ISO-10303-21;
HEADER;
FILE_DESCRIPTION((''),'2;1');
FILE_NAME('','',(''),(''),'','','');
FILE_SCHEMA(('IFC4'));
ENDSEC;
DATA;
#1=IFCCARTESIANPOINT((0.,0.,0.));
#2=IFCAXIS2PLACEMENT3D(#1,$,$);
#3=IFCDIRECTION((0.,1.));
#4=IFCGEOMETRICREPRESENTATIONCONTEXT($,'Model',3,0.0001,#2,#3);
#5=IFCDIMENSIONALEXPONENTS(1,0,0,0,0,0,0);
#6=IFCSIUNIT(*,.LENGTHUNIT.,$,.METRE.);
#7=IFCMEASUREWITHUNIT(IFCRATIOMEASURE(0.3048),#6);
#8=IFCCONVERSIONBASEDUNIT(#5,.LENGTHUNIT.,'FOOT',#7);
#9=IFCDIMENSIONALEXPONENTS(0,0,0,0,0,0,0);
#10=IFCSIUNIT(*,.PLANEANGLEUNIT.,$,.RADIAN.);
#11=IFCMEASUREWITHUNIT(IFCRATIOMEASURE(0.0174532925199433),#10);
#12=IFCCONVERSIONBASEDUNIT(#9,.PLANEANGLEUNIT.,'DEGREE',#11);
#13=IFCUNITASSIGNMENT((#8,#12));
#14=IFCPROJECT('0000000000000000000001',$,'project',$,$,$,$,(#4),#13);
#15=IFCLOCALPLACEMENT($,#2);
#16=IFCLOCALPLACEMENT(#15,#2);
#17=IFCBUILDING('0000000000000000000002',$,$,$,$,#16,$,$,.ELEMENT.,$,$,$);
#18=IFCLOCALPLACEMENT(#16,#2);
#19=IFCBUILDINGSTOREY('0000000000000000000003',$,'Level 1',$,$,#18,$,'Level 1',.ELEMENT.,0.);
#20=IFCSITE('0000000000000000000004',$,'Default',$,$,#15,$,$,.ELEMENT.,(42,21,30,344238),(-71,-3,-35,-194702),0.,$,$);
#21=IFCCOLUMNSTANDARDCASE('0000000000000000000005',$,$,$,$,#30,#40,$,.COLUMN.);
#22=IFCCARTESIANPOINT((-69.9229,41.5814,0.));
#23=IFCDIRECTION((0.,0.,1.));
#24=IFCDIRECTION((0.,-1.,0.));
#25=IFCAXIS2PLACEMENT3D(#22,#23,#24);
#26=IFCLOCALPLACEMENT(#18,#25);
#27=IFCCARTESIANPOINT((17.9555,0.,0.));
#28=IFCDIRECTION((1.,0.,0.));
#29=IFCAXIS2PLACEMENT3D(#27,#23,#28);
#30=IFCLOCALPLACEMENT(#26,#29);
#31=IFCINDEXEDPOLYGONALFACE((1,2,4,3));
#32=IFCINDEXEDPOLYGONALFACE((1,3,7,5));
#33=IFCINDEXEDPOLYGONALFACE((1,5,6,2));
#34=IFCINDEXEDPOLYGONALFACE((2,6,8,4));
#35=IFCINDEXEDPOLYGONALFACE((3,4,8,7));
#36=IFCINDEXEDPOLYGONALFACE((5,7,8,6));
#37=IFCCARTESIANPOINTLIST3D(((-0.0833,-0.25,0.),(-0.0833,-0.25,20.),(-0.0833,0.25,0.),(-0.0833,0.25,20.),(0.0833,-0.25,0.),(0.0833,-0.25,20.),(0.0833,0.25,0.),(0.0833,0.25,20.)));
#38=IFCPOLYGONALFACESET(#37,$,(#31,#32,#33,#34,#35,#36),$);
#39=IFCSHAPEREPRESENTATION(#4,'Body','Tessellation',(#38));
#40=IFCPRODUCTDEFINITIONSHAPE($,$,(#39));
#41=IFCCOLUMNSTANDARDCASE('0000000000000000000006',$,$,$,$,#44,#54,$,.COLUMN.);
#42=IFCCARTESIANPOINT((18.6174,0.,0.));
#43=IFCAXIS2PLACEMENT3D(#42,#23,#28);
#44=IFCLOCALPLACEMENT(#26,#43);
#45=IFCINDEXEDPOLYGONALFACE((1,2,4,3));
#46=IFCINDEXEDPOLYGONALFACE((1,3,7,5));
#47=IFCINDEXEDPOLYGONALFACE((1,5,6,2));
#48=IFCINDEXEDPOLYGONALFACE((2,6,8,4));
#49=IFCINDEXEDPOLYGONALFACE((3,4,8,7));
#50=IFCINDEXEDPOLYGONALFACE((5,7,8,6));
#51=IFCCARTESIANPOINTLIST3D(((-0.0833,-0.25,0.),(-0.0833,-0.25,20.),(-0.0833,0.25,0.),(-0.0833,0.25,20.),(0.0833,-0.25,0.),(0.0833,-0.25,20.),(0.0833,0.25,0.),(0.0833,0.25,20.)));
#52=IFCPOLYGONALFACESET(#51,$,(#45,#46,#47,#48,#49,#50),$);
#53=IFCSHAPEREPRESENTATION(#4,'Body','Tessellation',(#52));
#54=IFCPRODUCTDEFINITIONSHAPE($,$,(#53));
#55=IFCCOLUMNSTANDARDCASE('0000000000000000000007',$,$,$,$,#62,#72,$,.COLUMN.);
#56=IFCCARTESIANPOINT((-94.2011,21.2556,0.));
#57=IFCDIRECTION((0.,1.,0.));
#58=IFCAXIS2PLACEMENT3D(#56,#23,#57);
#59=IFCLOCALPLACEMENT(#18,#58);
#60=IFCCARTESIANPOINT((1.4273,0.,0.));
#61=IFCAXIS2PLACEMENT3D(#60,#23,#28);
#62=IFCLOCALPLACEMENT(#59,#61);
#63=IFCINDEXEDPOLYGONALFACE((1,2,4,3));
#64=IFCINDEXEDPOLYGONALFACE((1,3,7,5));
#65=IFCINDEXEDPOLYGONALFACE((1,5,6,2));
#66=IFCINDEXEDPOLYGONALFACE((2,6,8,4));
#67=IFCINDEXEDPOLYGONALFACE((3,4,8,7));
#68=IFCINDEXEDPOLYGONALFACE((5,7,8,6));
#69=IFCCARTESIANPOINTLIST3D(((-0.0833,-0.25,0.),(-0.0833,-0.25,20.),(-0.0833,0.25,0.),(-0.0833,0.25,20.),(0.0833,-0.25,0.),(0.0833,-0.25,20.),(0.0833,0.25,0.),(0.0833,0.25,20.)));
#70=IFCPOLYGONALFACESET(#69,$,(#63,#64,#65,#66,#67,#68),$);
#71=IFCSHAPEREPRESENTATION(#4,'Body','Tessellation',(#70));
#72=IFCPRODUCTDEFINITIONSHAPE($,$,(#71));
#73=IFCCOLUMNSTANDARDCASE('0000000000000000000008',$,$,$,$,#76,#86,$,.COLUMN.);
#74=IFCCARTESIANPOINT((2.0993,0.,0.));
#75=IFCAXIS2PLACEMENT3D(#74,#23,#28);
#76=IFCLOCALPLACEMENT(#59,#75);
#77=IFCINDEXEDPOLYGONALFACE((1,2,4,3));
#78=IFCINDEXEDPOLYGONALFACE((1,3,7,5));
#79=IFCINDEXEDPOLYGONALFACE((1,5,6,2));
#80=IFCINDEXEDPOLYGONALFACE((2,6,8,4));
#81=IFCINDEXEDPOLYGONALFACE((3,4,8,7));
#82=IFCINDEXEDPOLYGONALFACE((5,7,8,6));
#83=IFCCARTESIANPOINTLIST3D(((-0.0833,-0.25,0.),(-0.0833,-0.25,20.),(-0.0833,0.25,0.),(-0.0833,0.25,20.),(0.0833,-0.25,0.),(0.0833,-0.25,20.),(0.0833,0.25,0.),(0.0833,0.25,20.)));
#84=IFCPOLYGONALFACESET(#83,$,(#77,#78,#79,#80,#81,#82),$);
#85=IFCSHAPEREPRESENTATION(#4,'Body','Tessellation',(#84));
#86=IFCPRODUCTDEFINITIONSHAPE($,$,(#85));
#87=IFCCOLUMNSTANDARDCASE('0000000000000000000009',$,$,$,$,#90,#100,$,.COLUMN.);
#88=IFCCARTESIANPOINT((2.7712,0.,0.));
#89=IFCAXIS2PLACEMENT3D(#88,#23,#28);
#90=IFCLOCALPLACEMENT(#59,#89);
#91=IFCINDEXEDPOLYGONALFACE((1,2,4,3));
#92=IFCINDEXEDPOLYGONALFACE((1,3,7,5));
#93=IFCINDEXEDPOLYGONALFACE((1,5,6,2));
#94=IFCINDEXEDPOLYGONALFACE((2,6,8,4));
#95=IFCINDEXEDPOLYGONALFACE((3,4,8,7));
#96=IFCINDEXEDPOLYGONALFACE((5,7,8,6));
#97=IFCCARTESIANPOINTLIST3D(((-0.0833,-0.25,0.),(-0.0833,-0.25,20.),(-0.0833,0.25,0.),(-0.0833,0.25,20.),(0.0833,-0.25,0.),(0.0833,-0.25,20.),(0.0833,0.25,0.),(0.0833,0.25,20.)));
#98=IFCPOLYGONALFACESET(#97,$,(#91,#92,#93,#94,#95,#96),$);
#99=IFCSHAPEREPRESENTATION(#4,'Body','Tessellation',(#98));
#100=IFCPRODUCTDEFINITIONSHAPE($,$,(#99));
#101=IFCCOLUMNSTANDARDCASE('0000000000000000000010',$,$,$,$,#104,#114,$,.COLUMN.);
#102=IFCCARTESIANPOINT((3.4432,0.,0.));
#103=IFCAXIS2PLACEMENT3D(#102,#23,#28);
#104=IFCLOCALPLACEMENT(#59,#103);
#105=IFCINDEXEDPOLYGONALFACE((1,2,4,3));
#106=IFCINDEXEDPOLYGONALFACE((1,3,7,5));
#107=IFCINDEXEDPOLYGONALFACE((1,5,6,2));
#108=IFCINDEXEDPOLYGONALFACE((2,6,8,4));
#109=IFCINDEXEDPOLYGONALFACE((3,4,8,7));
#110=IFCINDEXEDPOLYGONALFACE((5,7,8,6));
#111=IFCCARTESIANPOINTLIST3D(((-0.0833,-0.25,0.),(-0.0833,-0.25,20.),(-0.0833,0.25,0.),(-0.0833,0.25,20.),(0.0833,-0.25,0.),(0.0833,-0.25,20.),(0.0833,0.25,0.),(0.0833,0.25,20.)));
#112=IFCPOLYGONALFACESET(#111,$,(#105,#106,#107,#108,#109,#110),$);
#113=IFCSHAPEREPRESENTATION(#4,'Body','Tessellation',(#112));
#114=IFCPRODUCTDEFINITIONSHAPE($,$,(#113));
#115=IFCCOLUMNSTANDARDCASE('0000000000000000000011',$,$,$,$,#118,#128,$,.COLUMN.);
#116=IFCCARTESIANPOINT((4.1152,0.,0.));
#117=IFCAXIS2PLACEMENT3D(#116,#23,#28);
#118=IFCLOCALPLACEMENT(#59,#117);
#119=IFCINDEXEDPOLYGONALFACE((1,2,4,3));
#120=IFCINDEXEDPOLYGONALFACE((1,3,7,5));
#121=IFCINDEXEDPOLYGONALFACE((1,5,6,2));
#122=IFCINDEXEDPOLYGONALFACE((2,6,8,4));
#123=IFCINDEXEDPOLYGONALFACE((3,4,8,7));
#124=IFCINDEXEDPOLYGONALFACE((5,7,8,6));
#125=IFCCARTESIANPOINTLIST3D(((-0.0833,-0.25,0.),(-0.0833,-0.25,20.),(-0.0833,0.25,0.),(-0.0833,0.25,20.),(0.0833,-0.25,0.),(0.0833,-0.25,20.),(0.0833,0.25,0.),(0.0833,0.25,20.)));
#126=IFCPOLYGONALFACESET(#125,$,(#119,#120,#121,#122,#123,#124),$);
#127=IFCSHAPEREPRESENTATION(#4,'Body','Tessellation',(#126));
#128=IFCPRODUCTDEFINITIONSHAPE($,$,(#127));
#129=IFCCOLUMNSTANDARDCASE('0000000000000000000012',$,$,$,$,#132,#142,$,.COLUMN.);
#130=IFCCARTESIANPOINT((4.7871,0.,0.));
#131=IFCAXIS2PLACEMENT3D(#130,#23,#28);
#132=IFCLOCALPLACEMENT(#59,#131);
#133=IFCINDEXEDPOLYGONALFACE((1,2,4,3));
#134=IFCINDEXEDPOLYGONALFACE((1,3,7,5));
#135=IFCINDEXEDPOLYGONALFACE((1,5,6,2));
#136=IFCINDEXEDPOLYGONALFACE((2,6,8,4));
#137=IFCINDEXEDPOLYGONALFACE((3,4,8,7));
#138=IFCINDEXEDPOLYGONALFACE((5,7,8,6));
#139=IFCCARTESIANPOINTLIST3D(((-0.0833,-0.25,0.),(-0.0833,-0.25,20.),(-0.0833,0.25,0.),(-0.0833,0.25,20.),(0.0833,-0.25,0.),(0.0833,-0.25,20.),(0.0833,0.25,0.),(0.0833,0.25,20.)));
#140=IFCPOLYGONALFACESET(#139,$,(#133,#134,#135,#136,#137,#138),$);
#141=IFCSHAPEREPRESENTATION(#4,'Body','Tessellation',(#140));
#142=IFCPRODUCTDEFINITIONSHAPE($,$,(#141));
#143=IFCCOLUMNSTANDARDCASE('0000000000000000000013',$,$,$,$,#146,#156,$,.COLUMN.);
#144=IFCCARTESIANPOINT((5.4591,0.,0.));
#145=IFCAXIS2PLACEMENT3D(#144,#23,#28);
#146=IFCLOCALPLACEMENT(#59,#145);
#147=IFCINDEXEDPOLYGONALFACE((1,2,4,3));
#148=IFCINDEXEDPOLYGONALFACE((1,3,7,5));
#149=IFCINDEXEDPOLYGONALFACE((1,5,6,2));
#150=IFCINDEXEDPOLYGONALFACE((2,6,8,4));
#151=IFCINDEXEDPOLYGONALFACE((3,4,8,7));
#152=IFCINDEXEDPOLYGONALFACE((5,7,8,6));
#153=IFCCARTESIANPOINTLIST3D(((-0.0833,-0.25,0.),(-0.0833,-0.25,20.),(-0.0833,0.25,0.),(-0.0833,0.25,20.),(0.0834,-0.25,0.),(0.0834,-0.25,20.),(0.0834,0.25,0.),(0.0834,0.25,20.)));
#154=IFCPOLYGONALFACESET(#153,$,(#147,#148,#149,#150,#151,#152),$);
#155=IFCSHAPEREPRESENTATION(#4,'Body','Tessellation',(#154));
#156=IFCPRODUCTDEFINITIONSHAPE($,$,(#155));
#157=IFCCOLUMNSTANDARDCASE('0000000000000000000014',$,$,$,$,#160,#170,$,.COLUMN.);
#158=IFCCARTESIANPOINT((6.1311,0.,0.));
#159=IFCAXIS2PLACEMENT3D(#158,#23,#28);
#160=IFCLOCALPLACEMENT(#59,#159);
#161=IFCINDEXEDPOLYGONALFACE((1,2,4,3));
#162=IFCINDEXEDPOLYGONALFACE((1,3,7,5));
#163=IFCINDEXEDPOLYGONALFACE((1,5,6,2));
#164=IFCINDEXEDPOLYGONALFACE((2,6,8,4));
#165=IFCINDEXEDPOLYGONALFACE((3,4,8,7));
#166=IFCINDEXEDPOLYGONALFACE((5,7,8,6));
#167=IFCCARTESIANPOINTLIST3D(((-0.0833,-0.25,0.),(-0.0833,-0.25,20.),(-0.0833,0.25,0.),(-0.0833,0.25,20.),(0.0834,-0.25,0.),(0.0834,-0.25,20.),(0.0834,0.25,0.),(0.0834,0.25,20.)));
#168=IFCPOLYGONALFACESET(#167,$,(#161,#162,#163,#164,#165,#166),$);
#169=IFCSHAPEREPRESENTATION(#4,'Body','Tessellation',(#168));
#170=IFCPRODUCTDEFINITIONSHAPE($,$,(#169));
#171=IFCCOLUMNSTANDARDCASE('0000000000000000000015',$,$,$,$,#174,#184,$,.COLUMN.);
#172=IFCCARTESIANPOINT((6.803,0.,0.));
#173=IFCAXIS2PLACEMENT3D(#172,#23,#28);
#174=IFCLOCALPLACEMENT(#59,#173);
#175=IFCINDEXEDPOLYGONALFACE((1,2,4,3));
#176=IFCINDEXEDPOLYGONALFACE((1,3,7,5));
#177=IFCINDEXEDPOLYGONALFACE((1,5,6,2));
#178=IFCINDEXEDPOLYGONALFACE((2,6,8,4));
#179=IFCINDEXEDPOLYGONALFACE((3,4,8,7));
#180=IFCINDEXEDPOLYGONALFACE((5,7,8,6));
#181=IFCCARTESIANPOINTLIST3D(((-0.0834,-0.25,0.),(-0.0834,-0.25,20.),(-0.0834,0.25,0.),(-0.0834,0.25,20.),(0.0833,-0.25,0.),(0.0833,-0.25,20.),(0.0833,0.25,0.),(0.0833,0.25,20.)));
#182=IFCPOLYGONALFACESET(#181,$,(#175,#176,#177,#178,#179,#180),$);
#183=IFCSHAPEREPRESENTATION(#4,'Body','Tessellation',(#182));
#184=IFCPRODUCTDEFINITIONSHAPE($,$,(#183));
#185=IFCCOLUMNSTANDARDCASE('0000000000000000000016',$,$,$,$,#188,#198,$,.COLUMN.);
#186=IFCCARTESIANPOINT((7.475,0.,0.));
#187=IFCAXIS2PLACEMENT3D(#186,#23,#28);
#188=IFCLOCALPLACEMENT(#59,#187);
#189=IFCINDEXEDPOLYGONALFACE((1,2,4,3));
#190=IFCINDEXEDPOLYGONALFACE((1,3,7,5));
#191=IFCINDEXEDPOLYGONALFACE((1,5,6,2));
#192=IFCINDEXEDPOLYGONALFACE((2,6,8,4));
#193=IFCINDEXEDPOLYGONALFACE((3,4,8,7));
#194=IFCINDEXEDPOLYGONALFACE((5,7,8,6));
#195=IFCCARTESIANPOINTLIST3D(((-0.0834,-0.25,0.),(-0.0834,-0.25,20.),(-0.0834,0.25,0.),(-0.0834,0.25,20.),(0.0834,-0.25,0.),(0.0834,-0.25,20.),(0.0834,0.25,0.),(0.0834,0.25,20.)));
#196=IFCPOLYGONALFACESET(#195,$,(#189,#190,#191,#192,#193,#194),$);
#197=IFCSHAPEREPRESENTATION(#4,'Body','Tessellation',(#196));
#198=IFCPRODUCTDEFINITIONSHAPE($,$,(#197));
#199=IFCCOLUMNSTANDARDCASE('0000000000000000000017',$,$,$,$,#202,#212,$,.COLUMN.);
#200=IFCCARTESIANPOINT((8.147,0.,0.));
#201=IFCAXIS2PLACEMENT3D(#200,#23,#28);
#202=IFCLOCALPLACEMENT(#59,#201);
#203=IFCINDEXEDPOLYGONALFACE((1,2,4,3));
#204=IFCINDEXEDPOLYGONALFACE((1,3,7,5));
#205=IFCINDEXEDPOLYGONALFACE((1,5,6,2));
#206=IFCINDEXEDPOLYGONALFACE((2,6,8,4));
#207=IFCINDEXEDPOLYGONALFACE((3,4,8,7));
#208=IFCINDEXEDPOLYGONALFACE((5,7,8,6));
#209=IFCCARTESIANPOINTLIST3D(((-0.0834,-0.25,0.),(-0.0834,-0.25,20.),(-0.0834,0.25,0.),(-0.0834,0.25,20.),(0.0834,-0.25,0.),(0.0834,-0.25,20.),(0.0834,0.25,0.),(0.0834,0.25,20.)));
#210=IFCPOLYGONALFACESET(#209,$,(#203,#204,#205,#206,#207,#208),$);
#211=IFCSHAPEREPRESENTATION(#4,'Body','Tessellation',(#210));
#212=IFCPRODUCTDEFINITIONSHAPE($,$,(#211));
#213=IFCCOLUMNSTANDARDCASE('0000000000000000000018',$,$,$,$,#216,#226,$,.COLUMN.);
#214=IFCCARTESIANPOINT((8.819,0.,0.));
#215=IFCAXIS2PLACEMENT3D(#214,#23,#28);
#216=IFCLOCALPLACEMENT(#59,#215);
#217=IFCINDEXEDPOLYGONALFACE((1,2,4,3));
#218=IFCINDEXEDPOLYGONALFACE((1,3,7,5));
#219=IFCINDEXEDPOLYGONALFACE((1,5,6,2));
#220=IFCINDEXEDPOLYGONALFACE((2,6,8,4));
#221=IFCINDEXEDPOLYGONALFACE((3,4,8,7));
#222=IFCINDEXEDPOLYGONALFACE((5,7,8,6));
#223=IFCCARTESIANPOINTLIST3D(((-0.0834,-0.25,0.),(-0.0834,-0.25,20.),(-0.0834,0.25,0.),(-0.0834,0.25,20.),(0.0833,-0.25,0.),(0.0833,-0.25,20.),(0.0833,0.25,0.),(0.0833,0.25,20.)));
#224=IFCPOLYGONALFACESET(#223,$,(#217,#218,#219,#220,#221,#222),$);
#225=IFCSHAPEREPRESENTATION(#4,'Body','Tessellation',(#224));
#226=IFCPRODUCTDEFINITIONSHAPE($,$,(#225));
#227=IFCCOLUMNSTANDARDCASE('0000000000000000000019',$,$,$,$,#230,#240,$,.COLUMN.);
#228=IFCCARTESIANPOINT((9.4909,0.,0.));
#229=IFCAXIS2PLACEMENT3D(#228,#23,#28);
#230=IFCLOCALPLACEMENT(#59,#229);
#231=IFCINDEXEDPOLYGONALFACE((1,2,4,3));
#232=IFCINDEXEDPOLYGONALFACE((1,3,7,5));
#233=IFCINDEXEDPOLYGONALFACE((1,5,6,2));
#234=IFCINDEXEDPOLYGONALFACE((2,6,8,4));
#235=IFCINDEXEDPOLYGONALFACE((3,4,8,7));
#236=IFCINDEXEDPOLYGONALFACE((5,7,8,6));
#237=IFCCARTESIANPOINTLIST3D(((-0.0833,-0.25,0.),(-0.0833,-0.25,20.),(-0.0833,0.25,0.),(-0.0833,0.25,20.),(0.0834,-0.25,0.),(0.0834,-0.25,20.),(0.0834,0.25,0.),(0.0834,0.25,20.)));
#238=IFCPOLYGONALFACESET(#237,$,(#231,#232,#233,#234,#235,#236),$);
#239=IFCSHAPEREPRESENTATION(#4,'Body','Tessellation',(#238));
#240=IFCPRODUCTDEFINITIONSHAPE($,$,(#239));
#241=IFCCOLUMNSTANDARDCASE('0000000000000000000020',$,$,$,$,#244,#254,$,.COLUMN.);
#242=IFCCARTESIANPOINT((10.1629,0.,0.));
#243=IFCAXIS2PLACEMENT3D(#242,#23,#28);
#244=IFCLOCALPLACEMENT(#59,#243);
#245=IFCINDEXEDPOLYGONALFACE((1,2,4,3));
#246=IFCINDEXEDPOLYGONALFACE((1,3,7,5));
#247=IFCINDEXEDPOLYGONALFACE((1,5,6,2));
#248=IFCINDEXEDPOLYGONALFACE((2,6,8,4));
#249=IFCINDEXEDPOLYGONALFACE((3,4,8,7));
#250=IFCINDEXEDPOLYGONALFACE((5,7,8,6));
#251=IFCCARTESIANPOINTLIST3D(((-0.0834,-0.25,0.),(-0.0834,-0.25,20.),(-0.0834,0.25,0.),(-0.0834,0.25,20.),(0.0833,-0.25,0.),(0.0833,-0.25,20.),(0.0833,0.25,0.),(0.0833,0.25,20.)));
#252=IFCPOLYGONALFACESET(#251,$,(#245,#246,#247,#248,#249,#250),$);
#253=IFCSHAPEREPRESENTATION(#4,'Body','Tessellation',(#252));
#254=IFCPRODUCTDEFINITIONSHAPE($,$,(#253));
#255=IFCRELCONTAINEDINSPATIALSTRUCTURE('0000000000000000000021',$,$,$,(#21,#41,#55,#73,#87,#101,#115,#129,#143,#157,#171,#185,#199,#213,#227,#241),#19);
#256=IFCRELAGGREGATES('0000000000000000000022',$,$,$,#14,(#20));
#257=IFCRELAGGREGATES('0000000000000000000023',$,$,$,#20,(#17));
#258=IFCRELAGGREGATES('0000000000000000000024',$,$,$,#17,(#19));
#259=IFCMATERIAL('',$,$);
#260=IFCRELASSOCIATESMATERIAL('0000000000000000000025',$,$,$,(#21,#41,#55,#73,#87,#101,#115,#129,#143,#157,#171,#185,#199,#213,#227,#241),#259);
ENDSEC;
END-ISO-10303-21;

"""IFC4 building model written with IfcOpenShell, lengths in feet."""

from ifc_helpers import new_model, entity, si_unit, converted_unit, direction, frame, origin, place, context, project, spatial, rectangle, extrude, material, element, save


model = new_model("IFC4")

# Units and contexts
model_context = context("Model", 3, precision=0.0001, world=origin(), true_north=direction((0.0, 1.0)))
ifc_project = project(units=[converted_unit("LENGTHUNIT", "FOOT", entity("IfcRatioMeasure", 0.3048), si_unit("LENGTHUNIT", "METRE"), dimensions=[1, 0, 0, 0, 0, 0, 0]), converted_unit("PLANEANGLEUNIT", "DEGREE", entity("IfcRatioMeasure", 0.0174532925199433), si_unit("PLANEANGLEUNIT", "RADIAN"), dimensions=[0, 0, 0, 0, 0, 0, 0])], contexts=[model_context])

# Site, building, storey
site_placement = place(None, origin())
site = spatial("IfcSite", under=ifc_project, at=site_placement, Name="Default", CompositionType="ELEMENT", RefLatitude=(42, 21, 30, 344238), RefLongitude=(-71, -3, -35, -194702), RefElevation=0.0)
building_placement = place(site_placement, origin())
building = spatial("IfcBuilding", under=site, at=building_placement, CompositionType="ELEMENT")
storey_placement = place(building_placement, origin())
storey = spatial("IfcBuildingStorey", under=building, at=storey_placement, Name="Level 1", LongName="Level 1", CompositionType="ELEMENT", Elevation=0.0)

# Columns
ifc_material_1 = material(Name="")
placement_1 = place(storey_placement, frame((-69.9229, 41.5814, 0.0), z_axis=(0.0, 0.0, 1.0), x_axis=(0.0, -1.0, 0.0)))
for number, where, z_axis, x_axis in (
    (1, (17.9555, 0.0, 0.0), (0.0, 0.0, 1.0), (1.0, 0.0, 0.0)),
    (2, (18.6174, 0.0, 0.0), (0.0, 0.0, 1.0), (1.0, 0.0, 0.0)),
):
    element("IfcColumnStandardCase", number, at=place(placement_1, frame(where, z_axis=z_axis, x_axis=x_axis)), inside=storey, material=ifc_material_1, PredefinedType="COLUMN", context=model_context, shape_type="SweptSolid", body=[
        extrude(rectangle(XDim=0.1667, YDim=0.5), origin(), (0.0, 0.0, 1.0), 20.0),
    ])
placement_2 = place(storey_placement, frame((-94.2011, 21.2556, 0.0), z_axis=(0.0, 0.0, 1.0), x_axis=(0.0, 1.0, 0.0)))
for number, where, z_axis, x_axis in (
    (3, (1.4273, 0.0, 0.0), (0.0, 0.0, 1.0), (1.0, 0.0, 0.0)),
    (4, (2.0993, 0.0, 0.0), (0.0, 0.0, 1.0), (1.0, 0.0, 0.0)),
    (5, (2.7712, 0.0, 0.0), (0.0, 0.0, 1.0), (1.0, 0.0, 0.0)),
    (6, (3.4432, 0.0, 0.0), (0.0, 0.0, 1.0), (1.0, 0.0, 0.0)),
    (7, (4.1152, 0.0, 0.0), (0.0, 0.0, 1.0), (1.0, 0.0, 0.0)),
    (8, (4.7871, 0.0, 0.0), (0.0, 0.0, 1.0), (1.0, 0.0, 0.0)),
    (9, (5.4591, 0.0, 0.0), (0.0, 0.0, 1.0), (1.0, 0.0, 0.0)),
    (10, (6.1311, 0.0, 0.0), (0.0, 0.0, 1.0), (1.0, 0.0, 0.0)),
    (11, (6.803, 0.0, 0.0), (0.0, 0.0, 1.0), (1.0, 0.0, 0.0)),
    (12, (7.475, 0.0, 0.0), (0.0, 0.0, 1.0), (1.0, 0.0, 0.0)),
    (13, (8.147, 0.0, 0.0), (0.0, 0.0, 1.0), (1.0, 0.0, 0.0)),
    (14, (8.819, 0.0, 0.0), (0.0, 0.0, 1.0), (1.0, 0.0, 0.0)),
    (15, (9.4909, 0.0, 0.0), (0.0, 0.0, 1.0), (1.0, 0.0, 0.0)),
    (16, (10.1629, 0.0, 0.0), (0.0, 0.0, 1.0), (1.0, 0.0, 0.0)),
):
    element("IfcColumnStandardCase", number, at=place(placement_2, frame(where, z_axis=z_axis, x_axis=x_axis)), inside=storey, material=ifc_material_1, PredefinedType="COLUMN", context=model_context, shape_type="SweptSolid", body=[
        extrude(rectangle(XDim=0.1667, YDim=0.5), origin(), (0.0, 0.0, 1.0), 20.0),
    ])

save(model, "model.ifc")
